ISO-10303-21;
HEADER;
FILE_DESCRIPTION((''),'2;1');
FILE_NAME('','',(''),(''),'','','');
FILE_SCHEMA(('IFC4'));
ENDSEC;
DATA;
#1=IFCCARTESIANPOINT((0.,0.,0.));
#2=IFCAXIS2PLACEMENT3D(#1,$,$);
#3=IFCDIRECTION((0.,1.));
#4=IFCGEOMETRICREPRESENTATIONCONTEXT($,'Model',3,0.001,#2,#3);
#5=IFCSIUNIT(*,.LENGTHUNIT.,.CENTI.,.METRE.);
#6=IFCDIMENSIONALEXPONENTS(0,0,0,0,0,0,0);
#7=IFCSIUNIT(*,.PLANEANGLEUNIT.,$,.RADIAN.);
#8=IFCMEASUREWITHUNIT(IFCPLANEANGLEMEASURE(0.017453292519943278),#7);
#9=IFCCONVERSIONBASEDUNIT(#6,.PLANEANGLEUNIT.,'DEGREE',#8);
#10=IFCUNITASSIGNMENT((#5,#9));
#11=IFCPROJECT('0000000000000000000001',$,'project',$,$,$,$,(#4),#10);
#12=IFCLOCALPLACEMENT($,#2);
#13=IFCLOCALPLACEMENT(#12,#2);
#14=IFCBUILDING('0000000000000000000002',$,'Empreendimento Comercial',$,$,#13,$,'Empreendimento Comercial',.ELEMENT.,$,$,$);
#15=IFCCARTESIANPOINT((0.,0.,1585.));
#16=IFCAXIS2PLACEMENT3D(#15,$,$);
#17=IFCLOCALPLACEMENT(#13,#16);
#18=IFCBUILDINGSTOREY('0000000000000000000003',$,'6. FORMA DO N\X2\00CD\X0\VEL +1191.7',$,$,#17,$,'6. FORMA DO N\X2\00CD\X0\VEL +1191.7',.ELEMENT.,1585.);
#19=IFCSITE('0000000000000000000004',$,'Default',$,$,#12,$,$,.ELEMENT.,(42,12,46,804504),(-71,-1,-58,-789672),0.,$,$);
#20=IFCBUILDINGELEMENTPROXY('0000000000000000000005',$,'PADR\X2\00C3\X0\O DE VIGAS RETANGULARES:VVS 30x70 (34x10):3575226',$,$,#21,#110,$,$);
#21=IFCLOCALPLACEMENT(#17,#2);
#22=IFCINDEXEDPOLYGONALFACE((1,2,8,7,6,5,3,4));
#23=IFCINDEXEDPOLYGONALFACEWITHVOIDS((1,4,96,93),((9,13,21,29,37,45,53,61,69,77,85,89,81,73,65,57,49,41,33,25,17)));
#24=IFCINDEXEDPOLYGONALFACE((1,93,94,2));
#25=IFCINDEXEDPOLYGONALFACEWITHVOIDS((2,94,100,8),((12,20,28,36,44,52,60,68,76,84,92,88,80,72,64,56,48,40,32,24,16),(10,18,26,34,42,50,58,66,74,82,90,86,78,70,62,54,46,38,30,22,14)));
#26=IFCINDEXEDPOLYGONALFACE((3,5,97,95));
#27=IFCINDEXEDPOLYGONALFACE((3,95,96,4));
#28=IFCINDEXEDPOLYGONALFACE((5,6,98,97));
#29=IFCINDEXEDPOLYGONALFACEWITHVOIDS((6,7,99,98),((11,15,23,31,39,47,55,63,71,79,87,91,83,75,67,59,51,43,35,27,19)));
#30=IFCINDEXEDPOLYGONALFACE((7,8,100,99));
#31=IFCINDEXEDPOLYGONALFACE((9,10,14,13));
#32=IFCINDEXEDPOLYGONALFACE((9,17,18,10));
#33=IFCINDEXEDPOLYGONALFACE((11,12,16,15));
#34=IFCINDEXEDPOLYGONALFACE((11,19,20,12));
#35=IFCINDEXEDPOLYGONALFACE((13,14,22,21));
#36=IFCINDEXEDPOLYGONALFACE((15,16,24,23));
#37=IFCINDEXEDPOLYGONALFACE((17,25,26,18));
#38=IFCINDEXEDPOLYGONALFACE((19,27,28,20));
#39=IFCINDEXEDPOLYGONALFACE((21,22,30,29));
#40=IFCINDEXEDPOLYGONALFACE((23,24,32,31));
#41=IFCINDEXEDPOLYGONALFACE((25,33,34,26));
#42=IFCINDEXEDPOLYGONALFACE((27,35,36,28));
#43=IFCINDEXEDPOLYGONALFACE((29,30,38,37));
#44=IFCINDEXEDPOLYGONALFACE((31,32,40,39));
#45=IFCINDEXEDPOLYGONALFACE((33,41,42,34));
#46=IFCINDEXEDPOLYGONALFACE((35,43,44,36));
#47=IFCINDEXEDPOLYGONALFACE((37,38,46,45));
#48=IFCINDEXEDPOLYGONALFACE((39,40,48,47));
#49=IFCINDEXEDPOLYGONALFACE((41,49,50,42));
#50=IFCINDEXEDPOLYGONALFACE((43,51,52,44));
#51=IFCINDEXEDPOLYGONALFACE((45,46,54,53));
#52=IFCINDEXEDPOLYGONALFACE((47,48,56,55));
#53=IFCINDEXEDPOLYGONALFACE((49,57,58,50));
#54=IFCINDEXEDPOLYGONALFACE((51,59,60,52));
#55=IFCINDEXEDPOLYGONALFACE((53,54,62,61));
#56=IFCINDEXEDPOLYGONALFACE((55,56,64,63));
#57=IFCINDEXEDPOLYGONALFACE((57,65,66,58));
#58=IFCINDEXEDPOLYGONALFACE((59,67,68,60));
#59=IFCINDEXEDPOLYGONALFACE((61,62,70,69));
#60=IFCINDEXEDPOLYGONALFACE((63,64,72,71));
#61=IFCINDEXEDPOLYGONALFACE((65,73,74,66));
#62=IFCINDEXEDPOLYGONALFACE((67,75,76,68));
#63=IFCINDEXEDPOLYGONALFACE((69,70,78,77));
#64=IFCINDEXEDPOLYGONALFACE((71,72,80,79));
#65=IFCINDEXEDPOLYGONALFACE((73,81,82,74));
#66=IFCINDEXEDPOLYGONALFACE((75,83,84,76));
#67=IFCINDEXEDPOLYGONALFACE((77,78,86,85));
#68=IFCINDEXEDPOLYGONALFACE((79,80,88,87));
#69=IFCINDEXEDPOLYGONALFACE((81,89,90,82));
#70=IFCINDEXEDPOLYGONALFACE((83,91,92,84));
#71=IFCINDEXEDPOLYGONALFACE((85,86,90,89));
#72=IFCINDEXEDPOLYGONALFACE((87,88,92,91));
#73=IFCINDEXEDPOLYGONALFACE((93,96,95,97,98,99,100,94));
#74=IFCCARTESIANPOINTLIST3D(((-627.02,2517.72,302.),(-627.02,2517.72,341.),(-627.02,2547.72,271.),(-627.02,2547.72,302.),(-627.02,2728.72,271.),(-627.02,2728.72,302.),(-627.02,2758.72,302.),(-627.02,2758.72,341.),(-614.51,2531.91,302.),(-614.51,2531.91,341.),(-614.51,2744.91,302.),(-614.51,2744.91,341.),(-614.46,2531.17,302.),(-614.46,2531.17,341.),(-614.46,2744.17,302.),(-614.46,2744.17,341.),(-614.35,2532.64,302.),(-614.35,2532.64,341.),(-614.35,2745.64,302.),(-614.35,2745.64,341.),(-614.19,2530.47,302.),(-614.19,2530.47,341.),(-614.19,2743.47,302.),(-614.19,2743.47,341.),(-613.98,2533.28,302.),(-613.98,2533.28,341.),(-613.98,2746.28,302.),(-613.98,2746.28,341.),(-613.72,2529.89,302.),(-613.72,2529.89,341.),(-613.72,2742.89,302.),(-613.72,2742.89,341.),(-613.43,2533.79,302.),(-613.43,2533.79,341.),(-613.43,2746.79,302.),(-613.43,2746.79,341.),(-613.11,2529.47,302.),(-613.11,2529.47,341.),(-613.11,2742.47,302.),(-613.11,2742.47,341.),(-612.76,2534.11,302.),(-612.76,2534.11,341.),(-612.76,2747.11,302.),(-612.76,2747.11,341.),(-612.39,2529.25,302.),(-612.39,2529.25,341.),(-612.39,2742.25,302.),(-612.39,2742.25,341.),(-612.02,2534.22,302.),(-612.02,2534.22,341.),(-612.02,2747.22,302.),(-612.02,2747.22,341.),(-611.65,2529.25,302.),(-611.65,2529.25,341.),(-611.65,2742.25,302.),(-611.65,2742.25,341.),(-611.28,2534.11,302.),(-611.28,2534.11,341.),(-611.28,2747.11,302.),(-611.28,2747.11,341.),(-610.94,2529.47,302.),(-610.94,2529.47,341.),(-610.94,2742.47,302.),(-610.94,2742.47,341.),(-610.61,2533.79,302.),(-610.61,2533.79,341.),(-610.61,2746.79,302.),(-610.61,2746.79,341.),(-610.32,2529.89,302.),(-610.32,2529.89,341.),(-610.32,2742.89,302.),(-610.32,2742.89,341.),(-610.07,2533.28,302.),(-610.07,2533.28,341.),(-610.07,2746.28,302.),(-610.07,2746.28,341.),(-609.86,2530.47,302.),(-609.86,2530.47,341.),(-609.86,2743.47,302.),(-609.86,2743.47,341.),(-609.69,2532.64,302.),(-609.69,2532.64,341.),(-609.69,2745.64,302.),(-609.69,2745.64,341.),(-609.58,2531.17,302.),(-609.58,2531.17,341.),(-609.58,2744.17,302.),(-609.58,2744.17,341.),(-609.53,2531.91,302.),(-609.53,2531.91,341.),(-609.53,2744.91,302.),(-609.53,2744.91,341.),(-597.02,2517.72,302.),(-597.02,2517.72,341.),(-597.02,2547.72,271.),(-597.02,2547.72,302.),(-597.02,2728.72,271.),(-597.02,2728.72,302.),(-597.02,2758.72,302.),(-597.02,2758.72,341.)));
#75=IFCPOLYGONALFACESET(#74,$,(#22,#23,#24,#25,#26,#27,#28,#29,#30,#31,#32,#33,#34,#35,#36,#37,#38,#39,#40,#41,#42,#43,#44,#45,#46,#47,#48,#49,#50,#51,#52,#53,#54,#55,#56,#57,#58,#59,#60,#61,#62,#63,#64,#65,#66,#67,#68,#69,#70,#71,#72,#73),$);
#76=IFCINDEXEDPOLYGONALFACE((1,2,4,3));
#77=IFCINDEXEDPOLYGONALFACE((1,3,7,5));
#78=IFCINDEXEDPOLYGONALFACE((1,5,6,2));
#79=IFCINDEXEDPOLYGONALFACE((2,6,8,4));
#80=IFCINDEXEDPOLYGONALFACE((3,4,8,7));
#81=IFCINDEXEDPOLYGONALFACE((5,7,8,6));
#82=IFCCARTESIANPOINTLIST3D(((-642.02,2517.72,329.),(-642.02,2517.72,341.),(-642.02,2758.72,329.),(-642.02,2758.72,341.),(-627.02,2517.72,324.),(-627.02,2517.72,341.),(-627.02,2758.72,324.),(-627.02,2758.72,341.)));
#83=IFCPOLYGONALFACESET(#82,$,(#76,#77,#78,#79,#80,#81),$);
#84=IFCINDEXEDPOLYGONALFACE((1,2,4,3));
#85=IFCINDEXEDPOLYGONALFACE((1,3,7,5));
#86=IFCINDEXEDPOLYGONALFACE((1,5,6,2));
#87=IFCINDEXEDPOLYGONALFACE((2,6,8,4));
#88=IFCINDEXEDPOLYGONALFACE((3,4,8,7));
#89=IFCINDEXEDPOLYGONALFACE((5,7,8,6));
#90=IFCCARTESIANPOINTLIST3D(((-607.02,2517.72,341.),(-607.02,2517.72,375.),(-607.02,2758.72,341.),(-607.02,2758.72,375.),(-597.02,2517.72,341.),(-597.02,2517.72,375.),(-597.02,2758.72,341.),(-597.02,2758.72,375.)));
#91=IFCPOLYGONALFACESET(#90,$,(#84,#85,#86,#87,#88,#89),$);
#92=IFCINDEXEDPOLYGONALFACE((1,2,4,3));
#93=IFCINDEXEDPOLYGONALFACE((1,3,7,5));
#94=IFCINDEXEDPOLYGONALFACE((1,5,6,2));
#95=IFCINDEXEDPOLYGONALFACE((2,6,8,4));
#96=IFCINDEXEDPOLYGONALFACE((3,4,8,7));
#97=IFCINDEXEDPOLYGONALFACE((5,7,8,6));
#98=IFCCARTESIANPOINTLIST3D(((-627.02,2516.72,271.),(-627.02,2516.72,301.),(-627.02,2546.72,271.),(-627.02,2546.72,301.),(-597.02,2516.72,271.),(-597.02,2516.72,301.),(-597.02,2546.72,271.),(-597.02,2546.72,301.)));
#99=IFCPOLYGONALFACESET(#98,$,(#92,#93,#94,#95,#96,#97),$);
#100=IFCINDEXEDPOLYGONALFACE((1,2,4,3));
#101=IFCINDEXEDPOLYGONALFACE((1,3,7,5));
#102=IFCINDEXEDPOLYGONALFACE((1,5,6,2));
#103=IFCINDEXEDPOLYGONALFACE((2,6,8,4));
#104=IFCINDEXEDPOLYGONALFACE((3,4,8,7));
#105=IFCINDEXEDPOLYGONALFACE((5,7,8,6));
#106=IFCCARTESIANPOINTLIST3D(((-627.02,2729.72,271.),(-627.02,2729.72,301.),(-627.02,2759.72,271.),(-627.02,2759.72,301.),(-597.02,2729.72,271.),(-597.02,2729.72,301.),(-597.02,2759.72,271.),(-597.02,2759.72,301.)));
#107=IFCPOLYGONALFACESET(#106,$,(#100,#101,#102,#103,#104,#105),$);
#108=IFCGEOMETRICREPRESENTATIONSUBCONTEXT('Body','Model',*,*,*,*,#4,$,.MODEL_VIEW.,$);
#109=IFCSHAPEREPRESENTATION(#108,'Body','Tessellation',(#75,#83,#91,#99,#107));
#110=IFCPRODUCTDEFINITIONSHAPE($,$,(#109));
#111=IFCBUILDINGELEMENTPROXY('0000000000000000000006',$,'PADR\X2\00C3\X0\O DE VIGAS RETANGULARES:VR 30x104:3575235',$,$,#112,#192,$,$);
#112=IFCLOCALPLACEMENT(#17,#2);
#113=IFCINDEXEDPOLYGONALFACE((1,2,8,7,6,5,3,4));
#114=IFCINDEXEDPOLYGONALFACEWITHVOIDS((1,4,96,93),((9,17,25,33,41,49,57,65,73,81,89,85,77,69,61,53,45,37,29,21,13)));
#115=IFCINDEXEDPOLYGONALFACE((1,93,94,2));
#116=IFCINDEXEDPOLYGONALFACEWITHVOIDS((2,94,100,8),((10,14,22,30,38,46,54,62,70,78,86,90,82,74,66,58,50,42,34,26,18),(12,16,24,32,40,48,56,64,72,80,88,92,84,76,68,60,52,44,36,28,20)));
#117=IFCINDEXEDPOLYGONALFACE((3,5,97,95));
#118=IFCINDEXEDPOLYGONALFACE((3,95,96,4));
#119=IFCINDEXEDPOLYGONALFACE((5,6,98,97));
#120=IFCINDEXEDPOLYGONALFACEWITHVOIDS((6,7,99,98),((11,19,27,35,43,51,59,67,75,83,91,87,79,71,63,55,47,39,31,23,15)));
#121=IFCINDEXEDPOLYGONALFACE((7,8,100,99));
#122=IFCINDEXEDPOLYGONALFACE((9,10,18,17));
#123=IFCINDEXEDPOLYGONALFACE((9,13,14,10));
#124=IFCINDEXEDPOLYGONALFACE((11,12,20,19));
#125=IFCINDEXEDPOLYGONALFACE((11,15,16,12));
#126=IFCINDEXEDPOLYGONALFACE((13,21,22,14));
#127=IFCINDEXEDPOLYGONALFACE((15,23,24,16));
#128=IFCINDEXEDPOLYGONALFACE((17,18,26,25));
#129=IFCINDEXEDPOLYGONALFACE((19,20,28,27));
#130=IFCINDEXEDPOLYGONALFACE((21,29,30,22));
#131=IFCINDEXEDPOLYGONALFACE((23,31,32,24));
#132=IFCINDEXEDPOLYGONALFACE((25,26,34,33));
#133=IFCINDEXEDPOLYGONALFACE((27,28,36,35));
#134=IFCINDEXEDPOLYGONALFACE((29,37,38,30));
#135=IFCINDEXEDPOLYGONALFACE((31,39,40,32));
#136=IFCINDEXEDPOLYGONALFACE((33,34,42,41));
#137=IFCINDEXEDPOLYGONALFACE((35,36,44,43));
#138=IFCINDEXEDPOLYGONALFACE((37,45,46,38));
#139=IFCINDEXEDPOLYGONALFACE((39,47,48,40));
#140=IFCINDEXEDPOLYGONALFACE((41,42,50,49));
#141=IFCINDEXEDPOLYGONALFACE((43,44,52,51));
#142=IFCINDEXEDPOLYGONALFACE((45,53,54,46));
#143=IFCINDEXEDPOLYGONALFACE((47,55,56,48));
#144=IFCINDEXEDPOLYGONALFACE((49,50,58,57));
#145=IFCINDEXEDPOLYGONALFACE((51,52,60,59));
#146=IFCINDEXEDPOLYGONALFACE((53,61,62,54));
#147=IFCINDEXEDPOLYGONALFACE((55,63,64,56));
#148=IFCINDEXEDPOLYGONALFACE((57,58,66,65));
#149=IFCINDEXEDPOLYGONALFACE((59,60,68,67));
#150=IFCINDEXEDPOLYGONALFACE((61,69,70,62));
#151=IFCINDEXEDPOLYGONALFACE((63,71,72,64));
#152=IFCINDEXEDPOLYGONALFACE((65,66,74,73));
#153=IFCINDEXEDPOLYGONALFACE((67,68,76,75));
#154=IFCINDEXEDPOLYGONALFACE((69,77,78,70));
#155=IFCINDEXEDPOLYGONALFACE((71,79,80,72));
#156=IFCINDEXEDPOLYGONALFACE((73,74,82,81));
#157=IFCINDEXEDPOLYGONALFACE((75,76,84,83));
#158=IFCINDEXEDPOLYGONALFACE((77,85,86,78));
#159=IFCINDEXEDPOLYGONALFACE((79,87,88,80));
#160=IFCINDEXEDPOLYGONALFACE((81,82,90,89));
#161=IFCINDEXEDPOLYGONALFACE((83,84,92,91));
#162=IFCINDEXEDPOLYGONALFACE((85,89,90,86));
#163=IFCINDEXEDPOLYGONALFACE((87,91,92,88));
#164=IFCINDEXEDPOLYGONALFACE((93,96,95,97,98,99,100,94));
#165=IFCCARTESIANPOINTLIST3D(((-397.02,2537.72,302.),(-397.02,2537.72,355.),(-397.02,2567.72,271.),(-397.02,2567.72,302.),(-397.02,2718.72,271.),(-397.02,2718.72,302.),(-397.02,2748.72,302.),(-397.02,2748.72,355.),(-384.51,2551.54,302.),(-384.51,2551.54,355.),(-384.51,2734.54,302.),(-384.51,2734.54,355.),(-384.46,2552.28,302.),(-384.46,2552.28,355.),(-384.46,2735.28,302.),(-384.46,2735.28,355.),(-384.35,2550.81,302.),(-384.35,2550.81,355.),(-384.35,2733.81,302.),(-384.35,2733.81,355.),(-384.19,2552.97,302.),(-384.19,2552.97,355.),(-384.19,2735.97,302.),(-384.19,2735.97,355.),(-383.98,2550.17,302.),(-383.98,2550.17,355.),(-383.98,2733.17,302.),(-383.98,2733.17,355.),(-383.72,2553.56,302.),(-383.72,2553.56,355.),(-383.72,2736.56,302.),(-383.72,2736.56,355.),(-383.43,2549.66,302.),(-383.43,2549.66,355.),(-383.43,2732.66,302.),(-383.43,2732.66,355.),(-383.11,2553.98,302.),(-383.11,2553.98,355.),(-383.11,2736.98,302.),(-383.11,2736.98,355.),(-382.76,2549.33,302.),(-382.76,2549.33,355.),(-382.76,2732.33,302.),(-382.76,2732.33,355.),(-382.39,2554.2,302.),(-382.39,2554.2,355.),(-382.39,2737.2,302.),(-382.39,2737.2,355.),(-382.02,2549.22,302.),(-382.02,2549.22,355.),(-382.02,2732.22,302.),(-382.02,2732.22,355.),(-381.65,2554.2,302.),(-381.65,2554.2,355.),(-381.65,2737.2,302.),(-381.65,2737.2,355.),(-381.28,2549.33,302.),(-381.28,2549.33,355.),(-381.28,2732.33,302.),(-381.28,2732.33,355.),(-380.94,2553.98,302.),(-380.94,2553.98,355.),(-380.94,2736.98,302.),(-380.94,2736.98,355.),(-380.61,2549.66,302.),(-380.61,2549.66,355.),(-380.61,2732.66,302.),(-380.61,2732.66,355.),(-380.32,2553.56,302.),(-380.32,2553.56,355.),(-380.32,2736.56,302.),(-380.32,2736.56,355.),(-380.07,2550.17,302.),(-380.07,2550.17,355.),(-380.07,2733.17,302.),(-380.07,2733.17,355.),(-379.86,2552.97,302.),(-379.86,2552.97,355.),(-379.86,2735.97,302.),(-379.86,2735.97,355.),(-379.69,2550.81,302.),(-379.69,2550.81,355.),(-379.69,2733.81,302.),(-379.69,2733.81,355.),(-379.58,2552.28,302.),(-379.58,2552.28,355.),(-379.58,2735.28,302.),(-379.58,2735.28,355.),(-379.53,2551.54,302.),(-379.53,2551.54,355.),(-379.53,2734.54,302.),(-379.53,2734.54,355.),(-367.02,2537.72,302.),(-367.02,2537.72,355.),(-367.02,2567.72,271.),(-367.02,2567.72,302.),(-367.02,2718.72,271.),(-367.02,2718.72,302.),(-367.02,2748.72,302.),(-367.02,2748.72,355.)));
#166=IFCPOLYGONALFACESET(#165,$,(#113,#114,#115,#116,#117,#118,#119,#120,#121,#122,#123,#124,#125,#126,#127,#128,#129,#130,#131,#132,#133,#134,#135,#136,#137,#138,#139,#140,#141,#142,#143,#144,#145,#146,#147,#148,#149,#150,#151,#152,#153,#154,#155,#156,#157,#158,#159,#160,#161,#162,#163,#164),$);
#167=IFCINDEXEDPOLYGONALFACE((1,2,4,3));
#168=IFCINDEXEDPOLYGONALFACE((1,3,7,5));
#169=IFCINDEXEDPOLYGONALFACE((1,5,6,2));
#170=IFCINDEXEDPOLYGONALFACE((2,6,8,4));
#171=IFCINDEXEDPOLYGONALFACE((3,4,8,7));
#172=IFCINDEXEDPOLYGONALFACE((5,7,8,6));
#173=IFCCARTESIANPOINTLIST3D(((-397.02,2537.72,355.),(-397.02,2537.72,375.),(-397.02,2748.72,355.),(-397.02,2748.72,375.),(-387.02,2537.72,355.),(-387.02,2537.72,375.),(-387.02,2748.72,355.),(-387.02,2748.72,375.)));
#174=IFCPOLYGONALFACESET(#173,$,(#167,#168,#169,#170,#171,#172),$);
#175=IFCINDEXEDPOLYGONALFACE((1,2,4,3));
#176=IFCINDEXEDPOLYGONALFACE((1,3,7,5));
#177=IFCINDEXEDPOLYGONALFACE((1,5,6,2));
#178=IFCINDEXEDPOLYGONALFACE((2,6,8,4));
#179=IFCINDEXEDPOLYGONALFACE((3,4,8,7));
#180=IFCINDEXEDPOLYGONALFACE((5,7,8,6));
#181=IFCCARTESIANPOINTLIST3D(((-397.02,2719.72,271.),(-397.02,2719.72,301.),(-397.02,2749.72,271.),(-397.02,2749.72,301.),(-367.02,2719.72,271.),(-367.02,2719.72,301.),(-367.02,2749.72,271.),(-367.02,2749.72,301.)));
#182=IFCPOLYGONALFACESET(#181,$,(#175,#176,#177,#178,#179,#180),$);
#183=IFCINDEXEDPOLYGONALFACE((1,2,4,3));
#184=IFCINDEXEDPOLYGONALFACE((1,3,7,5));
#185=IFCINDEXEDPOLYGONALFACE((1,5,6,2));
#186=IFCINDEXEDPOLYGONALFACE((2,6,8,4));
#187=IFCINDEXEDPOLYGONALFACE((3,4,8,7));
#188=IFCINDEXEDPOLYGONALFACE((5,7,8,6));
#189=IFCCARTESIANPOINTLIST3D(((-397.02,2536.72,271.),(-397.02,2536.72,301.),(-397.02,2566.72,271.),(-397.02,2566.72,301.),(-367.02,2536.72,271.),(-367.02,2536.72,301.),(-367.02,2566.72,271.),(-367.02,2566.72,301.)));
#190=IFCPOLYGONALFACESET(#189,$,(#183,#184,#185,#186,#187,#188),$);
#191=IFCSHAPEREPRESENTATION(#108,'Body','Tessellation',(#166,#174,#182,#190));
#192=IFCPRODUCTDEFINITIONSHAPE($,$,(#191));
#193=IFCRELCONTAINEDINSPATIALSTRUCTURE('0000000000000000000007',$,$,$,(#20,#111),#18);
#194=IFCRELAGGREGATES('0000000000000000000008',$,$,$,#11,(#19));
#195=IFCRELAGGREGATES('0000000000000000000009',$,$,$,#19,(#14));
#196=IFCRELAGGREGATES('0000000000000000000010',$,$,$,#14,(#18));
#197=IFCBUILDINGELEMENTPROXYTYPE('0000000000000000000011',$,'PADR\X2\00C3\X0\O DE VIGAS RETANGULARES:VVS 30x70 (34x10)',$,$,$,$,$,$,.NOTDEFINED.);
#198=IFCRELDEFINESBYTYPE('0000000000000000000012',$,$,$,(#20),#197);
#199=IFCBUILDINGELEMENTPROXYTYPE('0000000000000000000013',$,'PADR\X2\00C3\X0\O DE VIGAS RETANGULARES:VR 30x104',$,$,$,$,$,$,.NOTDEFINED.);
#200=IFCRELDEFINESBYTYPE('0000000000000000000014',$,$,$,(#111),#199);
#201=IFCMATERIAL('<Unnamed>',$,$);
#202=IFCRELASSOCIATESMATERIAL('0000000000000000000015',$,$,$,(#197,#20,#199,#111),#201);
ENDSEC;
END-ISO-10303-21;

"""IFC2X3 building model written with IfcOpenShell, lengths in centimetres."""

from ifc_helpers import new_model, entity, si_unit, converted_unit, direction, frame, frame_2d, origin, origin_2d_with_axis, place, context, subcontext, project, spatial, polyline, rectangle, circle, outline, extrude, source, transform, mapped, material, type_object, type_shapes, element, save


model = new_model("IFC2X3")

# Units and contexts
model_context = context("Model", 3, precision=0.001, world=origin(), true_north=direction((0.0, 1.0)))
body_context = subcontext(model_context, "Body", "Model", "MODEL_VIEW")
ifc_project = project(units=[si_unit("LENGTHUNIT", "METRE", prefix="CENTI"), converted_unit("PLANEANGLEUNIT", "DEGREE", entity("IfcPlaneAngleMeasure", 0.017453292519943278), si_unit("PLANEANGLEUNIT", "RADIAN"), dimensions=[0, 0, 0, 0, 0, 0, 0])], contexts=[model_context])

# Site, building, storey
site_placement = place(None, origin())
site = spatial("IfcSite", under=ifc_project, at=site_placement, Name="Default", CompositionType="ELEMENT", RefLatitude=(42, 12, 46, 804504), RefLongitude=(-71, -1, -58, -789672), RefElevation=0.0)
building_placement = place(site_placement, origin())
building = spatial("IfcBuilding", under=site, at=building_placement, Name="Empreendimento Comercial", LongName="Empreendimento Comercial", CompositionType="ELEMENT")
storey_placement = place(building_placement, frame((0.0, 0.0, 1585.0)))
storey = spatial("IfcBuildingStorey", under=building, at=storey_placement, Name="6. FORMA DO NÍVEL +1191.7", LongName="6. FORMA DO NÍVEL +1191.7", CompositionType="ELEMENT", Elevation=1585.0)

# Shared definitions
ifc_material = material(Name="<Unnamed>")

# Building element proxies, openings
building_element_proxy_type_1 = type_object("IfcBuildingElementProxyType", Name="PADRÃO DE VIGAS RETANGULARES:VVS 30x70 (34x10)", PredefinedType="NOTDEFINED", material=ifc_material)
shared_shape_1 = source(origin(), body_context, "Body", "SweptSolid", [
    extrude(outline(polyline([(-120.5, -37.0), (120.5, -37.0), (120.5, 2.0), (90.5, 2.0), (90.5, 33.0), (-90.5, 33.0), (-90.5, 2.0), (-120.5, 2.0), (-120.5, -37.0)])), frame((-627.02, 2638.22, 1889.0), z_axis=(1.0, 0.0, 0.0), x_axis=(0.0, -1.0, 0.0)), (0.0, 0.0, 1.0), 30.0),
    extrude(outline(polyline([(-7.5, -7.25), (7.5, -7.25), (7.5, 9.75), (-7.5, 4.75), (-7.5, -7.25)])), frame((-634.52, 2517.72, 1918.75), z_axis=(0.0, 1.0, 0.0), x_axis=(1.0, 0.0, 0.0)), (0.0, 0.0, 1.0), 241.0),
    extrude(rectangle(XDim=10.0, YDim=241.0, at=frame_2d((0.0, 0.0), x_axis=(1.0, 0.0))), frame((-602.02, 2638.22, 1926.0), z_axis=(0.0, 0.0, 1.0), x_axis=(-1.0, 0.0, 0.0)), (0.0, 0.0, 1.0), 34.0),
    extrude(rectangle(XDim=30.0, YDim=30.0, at=frame_2d((0.0, 0.0), x_axis=(1.0, 0.0))), frame((-612.02, 2531.72, 1856.0), z_axis=(0.0, 0.0, 1.0), x_axis=(0.0, -1.0, 0.0)), (0.0, 0.0, 1.0), 30.0),
    extrude(rectangle(XDim=30.0, YDim=30.0, at=frame_2d((0.0, 0.0), x_axis=(1.0, 0.0))), frame((-612.02, 2744.72, 1856.0), z_axis=(0.0, 0.0, 1.0), x_axis=(0.0, -1.0, 0.0)), (0.0, 0.0, 1.0), 30.0),
])
type_shapes(building_element_proxy_type_1, [shared_shape_1])
proxy_1_placement = place(storey_placement, frame((0.0, 0.0, -1585.0)))
proxy_1 = element("IfcBuildingElementProxy", 1, at=proxy_1_placement, inside=storey, type_object=building_element_proxy_type_1, material=ifc_material, Name="PADRÃO DE VIGAS RETANGULARES:VVS 30x70 (34x10):3575226", context=body_context, shape_type="MappedRepresentation", body=[
    mapped(shared_shape_1, transform((0.0, 0.0, 0.0), scale=1.0)),
])
opening_1_placement = place(storey_placement, frame((0.0, 0.0, -1585.0)))
element("IfcOpeningElement", 2, at=opening_1_placement, cuts=proxy_1, ObjectType="Opening", context=body_context, shape_type="SweptSolid", body=[
    extrude(circle(Radius=2.5, at=origin_2d_with_axis()), frame((-612.02, 2744.72, 1887.0), z_axis=(0.0, 0.0, 1.0), x_axis=(0.0, 1.0, 0.0)), (0.0, 0.0, 1.0), 39.0),
])
opening_2_placement = place(storey_placement, frame((0.0, 0.0, -1585.0)))
element("IfcOpeningElement", 3, at=opening_2_placement, cuts=proxy_1, ObjectType="Opening", context=body_context, shape_type="SweptSolid", body=[
    extrude(circle(Radius=2.5, at=origin_2d_with_axis()), frame((-612.02, 2531.72, 1887.0), z_axis=(0.0, 0.0, 1.0), x_axis=(0.0, 1.0, 0.0)), (0.0, 0.0, 1.0), 39.0),
])
building_element_proxy_type_2 = type_object("IfcBuildingElementProxyType", Name="PADRÃO DE VIGAS RETANGULARES:VR 30x104", PredefinedType="NOTDEFINED", material=ifc_material)
shared_shape_2 = source(origin(), body_context, "Body", "SweptSolid", [
    extrude(outline(polyline([(-105.5, -47.5), (105.5, -47.5), (105.5, 5.5), (75.5, 5.5), (75.5, 36.5), (-75.5, 36.5), (-75.5, 5.5), (-105.5, 5.5), (-105.5, -47.5)])), frame((-397.02, 2643.22, 1892.5), z_axis=(1.0, 0.0, 0.0), x_axis=(0.0, -1.0, 0.0)), (0.0, 0.0, 1.0), 30.0),
    extrude(rectangle(XDim=10.0, YDim=211.0, at=frame_2d((0.0, 0.0), x_axis=(1.0, 0.0))), frame((-392.02, 2643.22, 1940.0)), (0.0, 0.0, 1.0), 20.0),
    extrude(rectangle(XDim=30.0, YDim=30.0, at=frame_2d((0.0, 0.0), x_axis=(1.0, 0.0))), frame((-382.02, 2734.72, 1856.0), z_axis=(0.0, 0.0, 1.0), x_axis=(0.0, 1.0, 0.0)), (0.0, 0.0, 1.0), 30.0),
    extrude(rectangle(XDim=30.0, YDim=30.0, at=frame_2d((0.0, 0.0), x_axis=(1.0, 0.0))), frame((-382.02, 2551.72, 1856.0), z_axis=(0.0, 0.0, 1.0), x_axis=(0.0, 1.0, 0.0)), (0.0, 0.0, 1.0), 30.0),
])
type_shapes(building_element_proxy_type_2, [shared_shape_2])
proxy_2_placement = place(storey_placement, frame((0.0, 0.0, -1585.0)))
proxy_2 = element("IfcBuildingElementProxy", 4, at=proxy_2_placement, inside=storey, type_object=building_element_proxy_type_2, material=ifc_material, Name="PADRÃO DE VIGAS RETANGULARES:VR 30x104:3575235", context=body_context, shape_type="MappedRepresentation", body=[
    mapped(shared_shape_2, transform((0.0, 0.0, 0.0), scale=1.0)),
])
opening_3_placement = place(storey_placement, frame((0.0, 0.0, -1585.0)))
element("IfcOpeningElement", 5, at=opening_3_placement, cuts=proxy_2, ObjectType="Opening", context=body_context, shape_type="SweptSolid", body=[
    extrude(circle(Radius=2.5, at=origin_2d_with_axis()), frame((-382.02, 2551.72, 1887.0), z_axis=(0.0, 0.0, 1.0), x_axis=(0.0, -1.0, 0.0)), (0.0, 0.0, 1.0), 53.0),
])
opening_4_placement = place(storey_placement, frame((0.0, 0.0, -1585.0)))
element("IfcOpeningElement", 6, at=opening_4_placement, cuts=proxy_2, ObjectType="Opening", context=body_context, shape_type="SweptSolid", body=[
    extrude(circle(Radius=2.5, at=origin_2d_with_axis()), frame((-382.02, 2734.72, 1887.0), z_axis=(0.0, 0.0, 1.0), x_axis=(0.0, -1.0, 0.0)), (0.0, 0.0, 1.0), 53.0),
])

save(model, "model.ifc")
